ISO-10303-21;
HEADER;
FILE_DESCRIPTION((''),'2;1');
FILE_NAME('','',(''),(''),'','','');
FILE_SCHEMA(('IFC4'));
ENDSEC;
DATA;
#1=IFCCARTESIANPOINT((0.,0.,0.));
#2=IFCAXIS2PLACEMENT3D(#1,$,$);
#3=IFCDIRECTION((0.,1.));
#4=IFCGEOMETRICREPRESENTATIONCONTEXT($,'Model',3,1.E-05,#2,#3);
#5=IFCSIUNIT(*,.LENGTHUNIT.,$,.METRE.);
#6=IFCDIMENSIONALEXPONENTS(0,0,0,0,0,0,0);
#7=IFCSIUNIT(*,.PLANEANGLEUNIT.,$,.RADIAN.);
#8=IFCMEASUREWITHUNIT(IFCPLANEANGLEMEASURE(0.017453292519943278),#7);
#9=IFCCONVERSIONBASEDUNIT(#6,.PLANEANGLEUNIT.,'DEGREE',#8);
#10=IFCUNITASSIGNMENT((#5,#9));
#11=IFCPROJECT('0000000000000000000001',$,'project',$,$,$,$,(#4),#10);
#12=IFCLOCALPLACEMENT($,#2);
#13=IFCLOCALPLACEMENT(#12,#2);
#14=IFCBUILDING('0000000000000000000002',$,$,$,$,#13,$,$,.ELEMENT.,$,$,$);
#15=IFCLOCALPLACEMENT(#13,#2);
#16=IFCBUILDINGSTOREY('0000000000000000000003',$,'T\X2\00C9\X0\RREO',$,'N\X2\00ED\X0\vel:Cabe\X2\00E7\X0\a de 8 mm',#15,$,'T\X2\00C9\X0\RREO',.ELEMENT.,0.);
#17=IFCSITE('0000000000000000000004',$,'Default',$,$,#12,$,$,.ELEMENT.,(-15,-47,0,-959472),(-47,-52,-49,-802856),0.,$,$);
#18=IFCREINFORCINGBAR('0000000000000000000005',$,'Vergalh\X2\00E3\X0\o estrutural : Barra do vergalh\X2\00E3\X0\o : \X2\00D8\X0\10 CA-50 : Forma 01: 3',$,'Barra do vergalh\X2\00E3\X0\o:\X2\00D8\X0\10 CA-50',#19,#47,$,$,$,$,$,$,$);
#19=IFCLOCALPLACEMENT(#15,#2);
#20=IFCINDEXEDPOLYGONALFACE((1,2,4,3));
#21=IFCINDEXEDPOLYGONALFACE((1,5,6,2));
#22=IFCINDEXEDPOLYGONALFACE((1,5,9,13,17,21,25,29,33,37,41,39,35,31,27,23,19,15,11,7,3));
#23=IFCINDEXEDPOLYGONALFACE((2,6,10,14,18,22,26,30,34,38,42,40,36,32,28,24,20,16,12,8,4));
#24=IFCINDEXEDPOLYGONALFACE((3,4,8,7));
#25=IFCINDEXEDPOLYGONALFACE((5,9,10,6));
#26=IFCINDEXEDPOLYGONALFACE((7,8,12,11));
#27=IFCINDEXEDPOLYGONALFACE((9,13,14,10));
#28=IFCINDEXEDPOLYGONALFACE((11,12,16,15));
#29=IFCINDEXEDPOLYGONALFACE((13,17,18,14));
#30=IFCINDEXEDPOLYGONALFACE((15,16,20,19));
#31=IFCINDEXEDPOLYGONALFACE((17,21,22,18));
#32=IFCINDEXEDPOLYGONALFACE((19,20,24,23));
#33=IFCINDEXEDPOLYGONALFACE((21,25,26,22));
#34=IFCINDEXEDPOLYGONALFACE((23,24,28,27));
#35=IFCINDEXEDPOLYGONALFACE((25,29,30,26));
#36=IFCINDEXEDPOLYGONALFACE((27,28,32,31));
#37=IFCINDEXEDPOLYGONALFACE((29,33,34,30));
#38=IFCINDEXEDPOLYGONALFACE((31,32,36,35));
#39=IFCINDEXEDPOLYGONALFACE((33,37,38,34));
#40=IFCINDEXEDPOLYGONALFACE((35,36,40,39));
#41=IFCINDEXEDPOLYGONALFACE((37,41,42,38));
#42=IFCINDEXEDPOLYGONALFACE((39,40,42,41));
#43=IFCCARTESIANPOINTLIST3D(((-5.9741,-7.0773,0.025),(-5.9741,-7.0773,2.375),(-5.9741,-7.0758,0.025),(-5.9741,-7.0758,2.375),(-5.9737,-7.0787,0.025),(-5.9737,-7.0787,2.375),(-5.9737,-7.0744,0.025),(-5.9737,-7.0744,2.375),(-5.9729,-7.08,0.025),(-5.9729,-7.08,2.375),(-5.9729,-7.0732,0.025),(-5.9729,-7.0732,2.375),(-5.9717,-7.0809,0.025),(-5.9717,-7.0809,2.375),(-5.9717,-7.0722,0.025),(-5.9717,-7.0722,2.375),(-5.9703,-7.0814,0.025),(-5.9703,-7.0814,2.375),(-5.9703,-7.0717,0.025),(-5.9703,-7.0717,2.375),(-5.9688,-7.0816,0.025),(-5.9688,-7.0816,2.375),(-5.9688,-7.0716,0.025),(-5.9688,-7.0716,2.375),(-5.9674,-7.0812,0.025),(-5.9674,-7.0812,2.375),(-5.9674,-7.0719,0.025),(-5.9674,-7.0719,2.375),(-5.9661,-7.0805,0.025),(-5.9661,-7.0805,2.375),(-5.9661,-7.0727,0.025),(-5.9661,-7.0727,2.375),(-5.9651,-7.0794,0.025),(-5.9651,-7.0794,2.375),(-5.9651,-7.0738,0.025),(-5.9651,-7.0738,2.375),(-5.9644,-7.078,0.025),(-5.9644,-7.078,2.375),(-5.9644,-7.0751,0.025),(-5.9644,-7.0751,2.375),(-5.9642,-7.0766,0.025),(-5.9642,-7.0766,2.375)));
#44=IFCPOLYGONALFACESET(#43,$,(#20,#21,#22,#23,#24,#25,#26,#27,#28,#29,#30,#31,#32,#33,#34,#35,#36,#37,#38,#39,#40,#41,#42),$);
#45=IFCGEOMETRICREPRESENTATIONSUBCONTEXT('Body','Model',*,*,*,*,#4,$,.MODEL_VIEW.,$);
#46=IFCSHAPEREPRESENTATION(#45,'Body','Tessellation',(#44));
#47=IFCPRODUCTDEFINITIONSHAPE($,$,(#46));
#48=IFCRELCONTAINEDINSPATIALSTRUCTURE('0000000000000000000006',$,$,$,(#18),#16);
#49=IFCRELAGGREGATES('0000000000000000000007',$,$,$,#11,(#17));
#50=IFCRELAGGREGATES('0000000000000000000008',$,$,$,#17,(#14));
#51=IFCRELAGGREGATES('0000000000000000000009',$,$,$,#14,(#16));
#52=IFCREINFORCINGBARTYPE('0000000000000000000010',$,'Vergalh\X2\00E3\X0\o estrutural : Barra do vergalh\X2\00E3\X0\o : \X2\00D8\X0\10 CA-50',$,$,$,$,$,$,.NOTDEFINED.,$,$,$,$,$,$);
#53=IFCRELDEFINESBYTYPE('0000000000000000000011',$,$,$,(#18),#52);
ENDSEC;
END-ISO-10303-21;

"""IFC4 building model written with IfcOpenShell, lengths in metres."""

from ifc_helpers import new_model, entity, si_unit, converted_unit, direction, origin, place, context, subcontext, project, spatial, type_object, element, save


model = new_model("IFC4")

# Units and contexts
model_context = context("Model", 3, precision=1e-05, world=origin(), true_north=direction((0.0, 1.0)))
body_context = subcontext(model_context, "Body", "Model", "MODEL_VIEW")
ifc_project = project(units=[si_unit("LENGTHUNIT", "METRE"), converted_unit("PLANEANGLEUNIT", "DEGREE", entity("IfcPlaneAngleMeasure", 0.017453292519943278), si_unit("PLANEANGLEUNIT", "RADIAN"), dimensions=[0, 0, 0, 0, 0, 0, 0])], contexts=[model_context])

# Site, building, storey
site_placement = place(None, origin())
site = spatial("IfcSite", under=ifc_project, at=site_placement, Name="Default", CompositionType="ELEMENT", RefLatitude=(-15, -47, 0, -959472), RefLongitude=(-47, -52, -49, -802856), RefElevation=0.0)
building_placement = place(site_placement, origin())
building = spatial("IfcBuilding", under=site, at=building_placement, CompositionType="ELEMENT")
storey_placement = place(building_placement, origin())
storey = spatial("IfcBuildingStorey", under=building, at=storey_placement, Name="TÉRREO", ObjectType="Nível:Cabeça de 8 mm", LongName="TÉRREO", CompositionType="ELEMENT", Elevation=0.0)

# Reinforcing bar
reinforcing_bar_type_1 = type_object("IfcReinforcingBarType", Name="Vergalhão estrutural : Barra do vergalhão : Ø10 CA-50", PredefinedType="NOTDEFINED")
reinforcing_bar_1_placement = place(storey_placement, origin())
element("IfcReinforcingBar", 1, at=reinforcing_bar_1_placement, inside=storey, type_object=reinforcing_bar_type_1, Name="Vergalhão estrutural : Barra do vergalhão : Ø10 CA-50 : Forma 01: 3", ObjectType="Barra do vergalhão:Ø10 CA-50", context=body_context, shape_type="AdvancedSweptSolid", body=[
    entity("IfcSweptDiskSolid", entity("IfcIndexedPolyCurve", entity("IfcCartesianPointList3D", [[-5.9692, -7.0766, 0.025], [-5.9692, -7.0766, 2.375]]), None, False), 0.005, None, 0.0, 1.0),
])

save(model, "model.ifc")
